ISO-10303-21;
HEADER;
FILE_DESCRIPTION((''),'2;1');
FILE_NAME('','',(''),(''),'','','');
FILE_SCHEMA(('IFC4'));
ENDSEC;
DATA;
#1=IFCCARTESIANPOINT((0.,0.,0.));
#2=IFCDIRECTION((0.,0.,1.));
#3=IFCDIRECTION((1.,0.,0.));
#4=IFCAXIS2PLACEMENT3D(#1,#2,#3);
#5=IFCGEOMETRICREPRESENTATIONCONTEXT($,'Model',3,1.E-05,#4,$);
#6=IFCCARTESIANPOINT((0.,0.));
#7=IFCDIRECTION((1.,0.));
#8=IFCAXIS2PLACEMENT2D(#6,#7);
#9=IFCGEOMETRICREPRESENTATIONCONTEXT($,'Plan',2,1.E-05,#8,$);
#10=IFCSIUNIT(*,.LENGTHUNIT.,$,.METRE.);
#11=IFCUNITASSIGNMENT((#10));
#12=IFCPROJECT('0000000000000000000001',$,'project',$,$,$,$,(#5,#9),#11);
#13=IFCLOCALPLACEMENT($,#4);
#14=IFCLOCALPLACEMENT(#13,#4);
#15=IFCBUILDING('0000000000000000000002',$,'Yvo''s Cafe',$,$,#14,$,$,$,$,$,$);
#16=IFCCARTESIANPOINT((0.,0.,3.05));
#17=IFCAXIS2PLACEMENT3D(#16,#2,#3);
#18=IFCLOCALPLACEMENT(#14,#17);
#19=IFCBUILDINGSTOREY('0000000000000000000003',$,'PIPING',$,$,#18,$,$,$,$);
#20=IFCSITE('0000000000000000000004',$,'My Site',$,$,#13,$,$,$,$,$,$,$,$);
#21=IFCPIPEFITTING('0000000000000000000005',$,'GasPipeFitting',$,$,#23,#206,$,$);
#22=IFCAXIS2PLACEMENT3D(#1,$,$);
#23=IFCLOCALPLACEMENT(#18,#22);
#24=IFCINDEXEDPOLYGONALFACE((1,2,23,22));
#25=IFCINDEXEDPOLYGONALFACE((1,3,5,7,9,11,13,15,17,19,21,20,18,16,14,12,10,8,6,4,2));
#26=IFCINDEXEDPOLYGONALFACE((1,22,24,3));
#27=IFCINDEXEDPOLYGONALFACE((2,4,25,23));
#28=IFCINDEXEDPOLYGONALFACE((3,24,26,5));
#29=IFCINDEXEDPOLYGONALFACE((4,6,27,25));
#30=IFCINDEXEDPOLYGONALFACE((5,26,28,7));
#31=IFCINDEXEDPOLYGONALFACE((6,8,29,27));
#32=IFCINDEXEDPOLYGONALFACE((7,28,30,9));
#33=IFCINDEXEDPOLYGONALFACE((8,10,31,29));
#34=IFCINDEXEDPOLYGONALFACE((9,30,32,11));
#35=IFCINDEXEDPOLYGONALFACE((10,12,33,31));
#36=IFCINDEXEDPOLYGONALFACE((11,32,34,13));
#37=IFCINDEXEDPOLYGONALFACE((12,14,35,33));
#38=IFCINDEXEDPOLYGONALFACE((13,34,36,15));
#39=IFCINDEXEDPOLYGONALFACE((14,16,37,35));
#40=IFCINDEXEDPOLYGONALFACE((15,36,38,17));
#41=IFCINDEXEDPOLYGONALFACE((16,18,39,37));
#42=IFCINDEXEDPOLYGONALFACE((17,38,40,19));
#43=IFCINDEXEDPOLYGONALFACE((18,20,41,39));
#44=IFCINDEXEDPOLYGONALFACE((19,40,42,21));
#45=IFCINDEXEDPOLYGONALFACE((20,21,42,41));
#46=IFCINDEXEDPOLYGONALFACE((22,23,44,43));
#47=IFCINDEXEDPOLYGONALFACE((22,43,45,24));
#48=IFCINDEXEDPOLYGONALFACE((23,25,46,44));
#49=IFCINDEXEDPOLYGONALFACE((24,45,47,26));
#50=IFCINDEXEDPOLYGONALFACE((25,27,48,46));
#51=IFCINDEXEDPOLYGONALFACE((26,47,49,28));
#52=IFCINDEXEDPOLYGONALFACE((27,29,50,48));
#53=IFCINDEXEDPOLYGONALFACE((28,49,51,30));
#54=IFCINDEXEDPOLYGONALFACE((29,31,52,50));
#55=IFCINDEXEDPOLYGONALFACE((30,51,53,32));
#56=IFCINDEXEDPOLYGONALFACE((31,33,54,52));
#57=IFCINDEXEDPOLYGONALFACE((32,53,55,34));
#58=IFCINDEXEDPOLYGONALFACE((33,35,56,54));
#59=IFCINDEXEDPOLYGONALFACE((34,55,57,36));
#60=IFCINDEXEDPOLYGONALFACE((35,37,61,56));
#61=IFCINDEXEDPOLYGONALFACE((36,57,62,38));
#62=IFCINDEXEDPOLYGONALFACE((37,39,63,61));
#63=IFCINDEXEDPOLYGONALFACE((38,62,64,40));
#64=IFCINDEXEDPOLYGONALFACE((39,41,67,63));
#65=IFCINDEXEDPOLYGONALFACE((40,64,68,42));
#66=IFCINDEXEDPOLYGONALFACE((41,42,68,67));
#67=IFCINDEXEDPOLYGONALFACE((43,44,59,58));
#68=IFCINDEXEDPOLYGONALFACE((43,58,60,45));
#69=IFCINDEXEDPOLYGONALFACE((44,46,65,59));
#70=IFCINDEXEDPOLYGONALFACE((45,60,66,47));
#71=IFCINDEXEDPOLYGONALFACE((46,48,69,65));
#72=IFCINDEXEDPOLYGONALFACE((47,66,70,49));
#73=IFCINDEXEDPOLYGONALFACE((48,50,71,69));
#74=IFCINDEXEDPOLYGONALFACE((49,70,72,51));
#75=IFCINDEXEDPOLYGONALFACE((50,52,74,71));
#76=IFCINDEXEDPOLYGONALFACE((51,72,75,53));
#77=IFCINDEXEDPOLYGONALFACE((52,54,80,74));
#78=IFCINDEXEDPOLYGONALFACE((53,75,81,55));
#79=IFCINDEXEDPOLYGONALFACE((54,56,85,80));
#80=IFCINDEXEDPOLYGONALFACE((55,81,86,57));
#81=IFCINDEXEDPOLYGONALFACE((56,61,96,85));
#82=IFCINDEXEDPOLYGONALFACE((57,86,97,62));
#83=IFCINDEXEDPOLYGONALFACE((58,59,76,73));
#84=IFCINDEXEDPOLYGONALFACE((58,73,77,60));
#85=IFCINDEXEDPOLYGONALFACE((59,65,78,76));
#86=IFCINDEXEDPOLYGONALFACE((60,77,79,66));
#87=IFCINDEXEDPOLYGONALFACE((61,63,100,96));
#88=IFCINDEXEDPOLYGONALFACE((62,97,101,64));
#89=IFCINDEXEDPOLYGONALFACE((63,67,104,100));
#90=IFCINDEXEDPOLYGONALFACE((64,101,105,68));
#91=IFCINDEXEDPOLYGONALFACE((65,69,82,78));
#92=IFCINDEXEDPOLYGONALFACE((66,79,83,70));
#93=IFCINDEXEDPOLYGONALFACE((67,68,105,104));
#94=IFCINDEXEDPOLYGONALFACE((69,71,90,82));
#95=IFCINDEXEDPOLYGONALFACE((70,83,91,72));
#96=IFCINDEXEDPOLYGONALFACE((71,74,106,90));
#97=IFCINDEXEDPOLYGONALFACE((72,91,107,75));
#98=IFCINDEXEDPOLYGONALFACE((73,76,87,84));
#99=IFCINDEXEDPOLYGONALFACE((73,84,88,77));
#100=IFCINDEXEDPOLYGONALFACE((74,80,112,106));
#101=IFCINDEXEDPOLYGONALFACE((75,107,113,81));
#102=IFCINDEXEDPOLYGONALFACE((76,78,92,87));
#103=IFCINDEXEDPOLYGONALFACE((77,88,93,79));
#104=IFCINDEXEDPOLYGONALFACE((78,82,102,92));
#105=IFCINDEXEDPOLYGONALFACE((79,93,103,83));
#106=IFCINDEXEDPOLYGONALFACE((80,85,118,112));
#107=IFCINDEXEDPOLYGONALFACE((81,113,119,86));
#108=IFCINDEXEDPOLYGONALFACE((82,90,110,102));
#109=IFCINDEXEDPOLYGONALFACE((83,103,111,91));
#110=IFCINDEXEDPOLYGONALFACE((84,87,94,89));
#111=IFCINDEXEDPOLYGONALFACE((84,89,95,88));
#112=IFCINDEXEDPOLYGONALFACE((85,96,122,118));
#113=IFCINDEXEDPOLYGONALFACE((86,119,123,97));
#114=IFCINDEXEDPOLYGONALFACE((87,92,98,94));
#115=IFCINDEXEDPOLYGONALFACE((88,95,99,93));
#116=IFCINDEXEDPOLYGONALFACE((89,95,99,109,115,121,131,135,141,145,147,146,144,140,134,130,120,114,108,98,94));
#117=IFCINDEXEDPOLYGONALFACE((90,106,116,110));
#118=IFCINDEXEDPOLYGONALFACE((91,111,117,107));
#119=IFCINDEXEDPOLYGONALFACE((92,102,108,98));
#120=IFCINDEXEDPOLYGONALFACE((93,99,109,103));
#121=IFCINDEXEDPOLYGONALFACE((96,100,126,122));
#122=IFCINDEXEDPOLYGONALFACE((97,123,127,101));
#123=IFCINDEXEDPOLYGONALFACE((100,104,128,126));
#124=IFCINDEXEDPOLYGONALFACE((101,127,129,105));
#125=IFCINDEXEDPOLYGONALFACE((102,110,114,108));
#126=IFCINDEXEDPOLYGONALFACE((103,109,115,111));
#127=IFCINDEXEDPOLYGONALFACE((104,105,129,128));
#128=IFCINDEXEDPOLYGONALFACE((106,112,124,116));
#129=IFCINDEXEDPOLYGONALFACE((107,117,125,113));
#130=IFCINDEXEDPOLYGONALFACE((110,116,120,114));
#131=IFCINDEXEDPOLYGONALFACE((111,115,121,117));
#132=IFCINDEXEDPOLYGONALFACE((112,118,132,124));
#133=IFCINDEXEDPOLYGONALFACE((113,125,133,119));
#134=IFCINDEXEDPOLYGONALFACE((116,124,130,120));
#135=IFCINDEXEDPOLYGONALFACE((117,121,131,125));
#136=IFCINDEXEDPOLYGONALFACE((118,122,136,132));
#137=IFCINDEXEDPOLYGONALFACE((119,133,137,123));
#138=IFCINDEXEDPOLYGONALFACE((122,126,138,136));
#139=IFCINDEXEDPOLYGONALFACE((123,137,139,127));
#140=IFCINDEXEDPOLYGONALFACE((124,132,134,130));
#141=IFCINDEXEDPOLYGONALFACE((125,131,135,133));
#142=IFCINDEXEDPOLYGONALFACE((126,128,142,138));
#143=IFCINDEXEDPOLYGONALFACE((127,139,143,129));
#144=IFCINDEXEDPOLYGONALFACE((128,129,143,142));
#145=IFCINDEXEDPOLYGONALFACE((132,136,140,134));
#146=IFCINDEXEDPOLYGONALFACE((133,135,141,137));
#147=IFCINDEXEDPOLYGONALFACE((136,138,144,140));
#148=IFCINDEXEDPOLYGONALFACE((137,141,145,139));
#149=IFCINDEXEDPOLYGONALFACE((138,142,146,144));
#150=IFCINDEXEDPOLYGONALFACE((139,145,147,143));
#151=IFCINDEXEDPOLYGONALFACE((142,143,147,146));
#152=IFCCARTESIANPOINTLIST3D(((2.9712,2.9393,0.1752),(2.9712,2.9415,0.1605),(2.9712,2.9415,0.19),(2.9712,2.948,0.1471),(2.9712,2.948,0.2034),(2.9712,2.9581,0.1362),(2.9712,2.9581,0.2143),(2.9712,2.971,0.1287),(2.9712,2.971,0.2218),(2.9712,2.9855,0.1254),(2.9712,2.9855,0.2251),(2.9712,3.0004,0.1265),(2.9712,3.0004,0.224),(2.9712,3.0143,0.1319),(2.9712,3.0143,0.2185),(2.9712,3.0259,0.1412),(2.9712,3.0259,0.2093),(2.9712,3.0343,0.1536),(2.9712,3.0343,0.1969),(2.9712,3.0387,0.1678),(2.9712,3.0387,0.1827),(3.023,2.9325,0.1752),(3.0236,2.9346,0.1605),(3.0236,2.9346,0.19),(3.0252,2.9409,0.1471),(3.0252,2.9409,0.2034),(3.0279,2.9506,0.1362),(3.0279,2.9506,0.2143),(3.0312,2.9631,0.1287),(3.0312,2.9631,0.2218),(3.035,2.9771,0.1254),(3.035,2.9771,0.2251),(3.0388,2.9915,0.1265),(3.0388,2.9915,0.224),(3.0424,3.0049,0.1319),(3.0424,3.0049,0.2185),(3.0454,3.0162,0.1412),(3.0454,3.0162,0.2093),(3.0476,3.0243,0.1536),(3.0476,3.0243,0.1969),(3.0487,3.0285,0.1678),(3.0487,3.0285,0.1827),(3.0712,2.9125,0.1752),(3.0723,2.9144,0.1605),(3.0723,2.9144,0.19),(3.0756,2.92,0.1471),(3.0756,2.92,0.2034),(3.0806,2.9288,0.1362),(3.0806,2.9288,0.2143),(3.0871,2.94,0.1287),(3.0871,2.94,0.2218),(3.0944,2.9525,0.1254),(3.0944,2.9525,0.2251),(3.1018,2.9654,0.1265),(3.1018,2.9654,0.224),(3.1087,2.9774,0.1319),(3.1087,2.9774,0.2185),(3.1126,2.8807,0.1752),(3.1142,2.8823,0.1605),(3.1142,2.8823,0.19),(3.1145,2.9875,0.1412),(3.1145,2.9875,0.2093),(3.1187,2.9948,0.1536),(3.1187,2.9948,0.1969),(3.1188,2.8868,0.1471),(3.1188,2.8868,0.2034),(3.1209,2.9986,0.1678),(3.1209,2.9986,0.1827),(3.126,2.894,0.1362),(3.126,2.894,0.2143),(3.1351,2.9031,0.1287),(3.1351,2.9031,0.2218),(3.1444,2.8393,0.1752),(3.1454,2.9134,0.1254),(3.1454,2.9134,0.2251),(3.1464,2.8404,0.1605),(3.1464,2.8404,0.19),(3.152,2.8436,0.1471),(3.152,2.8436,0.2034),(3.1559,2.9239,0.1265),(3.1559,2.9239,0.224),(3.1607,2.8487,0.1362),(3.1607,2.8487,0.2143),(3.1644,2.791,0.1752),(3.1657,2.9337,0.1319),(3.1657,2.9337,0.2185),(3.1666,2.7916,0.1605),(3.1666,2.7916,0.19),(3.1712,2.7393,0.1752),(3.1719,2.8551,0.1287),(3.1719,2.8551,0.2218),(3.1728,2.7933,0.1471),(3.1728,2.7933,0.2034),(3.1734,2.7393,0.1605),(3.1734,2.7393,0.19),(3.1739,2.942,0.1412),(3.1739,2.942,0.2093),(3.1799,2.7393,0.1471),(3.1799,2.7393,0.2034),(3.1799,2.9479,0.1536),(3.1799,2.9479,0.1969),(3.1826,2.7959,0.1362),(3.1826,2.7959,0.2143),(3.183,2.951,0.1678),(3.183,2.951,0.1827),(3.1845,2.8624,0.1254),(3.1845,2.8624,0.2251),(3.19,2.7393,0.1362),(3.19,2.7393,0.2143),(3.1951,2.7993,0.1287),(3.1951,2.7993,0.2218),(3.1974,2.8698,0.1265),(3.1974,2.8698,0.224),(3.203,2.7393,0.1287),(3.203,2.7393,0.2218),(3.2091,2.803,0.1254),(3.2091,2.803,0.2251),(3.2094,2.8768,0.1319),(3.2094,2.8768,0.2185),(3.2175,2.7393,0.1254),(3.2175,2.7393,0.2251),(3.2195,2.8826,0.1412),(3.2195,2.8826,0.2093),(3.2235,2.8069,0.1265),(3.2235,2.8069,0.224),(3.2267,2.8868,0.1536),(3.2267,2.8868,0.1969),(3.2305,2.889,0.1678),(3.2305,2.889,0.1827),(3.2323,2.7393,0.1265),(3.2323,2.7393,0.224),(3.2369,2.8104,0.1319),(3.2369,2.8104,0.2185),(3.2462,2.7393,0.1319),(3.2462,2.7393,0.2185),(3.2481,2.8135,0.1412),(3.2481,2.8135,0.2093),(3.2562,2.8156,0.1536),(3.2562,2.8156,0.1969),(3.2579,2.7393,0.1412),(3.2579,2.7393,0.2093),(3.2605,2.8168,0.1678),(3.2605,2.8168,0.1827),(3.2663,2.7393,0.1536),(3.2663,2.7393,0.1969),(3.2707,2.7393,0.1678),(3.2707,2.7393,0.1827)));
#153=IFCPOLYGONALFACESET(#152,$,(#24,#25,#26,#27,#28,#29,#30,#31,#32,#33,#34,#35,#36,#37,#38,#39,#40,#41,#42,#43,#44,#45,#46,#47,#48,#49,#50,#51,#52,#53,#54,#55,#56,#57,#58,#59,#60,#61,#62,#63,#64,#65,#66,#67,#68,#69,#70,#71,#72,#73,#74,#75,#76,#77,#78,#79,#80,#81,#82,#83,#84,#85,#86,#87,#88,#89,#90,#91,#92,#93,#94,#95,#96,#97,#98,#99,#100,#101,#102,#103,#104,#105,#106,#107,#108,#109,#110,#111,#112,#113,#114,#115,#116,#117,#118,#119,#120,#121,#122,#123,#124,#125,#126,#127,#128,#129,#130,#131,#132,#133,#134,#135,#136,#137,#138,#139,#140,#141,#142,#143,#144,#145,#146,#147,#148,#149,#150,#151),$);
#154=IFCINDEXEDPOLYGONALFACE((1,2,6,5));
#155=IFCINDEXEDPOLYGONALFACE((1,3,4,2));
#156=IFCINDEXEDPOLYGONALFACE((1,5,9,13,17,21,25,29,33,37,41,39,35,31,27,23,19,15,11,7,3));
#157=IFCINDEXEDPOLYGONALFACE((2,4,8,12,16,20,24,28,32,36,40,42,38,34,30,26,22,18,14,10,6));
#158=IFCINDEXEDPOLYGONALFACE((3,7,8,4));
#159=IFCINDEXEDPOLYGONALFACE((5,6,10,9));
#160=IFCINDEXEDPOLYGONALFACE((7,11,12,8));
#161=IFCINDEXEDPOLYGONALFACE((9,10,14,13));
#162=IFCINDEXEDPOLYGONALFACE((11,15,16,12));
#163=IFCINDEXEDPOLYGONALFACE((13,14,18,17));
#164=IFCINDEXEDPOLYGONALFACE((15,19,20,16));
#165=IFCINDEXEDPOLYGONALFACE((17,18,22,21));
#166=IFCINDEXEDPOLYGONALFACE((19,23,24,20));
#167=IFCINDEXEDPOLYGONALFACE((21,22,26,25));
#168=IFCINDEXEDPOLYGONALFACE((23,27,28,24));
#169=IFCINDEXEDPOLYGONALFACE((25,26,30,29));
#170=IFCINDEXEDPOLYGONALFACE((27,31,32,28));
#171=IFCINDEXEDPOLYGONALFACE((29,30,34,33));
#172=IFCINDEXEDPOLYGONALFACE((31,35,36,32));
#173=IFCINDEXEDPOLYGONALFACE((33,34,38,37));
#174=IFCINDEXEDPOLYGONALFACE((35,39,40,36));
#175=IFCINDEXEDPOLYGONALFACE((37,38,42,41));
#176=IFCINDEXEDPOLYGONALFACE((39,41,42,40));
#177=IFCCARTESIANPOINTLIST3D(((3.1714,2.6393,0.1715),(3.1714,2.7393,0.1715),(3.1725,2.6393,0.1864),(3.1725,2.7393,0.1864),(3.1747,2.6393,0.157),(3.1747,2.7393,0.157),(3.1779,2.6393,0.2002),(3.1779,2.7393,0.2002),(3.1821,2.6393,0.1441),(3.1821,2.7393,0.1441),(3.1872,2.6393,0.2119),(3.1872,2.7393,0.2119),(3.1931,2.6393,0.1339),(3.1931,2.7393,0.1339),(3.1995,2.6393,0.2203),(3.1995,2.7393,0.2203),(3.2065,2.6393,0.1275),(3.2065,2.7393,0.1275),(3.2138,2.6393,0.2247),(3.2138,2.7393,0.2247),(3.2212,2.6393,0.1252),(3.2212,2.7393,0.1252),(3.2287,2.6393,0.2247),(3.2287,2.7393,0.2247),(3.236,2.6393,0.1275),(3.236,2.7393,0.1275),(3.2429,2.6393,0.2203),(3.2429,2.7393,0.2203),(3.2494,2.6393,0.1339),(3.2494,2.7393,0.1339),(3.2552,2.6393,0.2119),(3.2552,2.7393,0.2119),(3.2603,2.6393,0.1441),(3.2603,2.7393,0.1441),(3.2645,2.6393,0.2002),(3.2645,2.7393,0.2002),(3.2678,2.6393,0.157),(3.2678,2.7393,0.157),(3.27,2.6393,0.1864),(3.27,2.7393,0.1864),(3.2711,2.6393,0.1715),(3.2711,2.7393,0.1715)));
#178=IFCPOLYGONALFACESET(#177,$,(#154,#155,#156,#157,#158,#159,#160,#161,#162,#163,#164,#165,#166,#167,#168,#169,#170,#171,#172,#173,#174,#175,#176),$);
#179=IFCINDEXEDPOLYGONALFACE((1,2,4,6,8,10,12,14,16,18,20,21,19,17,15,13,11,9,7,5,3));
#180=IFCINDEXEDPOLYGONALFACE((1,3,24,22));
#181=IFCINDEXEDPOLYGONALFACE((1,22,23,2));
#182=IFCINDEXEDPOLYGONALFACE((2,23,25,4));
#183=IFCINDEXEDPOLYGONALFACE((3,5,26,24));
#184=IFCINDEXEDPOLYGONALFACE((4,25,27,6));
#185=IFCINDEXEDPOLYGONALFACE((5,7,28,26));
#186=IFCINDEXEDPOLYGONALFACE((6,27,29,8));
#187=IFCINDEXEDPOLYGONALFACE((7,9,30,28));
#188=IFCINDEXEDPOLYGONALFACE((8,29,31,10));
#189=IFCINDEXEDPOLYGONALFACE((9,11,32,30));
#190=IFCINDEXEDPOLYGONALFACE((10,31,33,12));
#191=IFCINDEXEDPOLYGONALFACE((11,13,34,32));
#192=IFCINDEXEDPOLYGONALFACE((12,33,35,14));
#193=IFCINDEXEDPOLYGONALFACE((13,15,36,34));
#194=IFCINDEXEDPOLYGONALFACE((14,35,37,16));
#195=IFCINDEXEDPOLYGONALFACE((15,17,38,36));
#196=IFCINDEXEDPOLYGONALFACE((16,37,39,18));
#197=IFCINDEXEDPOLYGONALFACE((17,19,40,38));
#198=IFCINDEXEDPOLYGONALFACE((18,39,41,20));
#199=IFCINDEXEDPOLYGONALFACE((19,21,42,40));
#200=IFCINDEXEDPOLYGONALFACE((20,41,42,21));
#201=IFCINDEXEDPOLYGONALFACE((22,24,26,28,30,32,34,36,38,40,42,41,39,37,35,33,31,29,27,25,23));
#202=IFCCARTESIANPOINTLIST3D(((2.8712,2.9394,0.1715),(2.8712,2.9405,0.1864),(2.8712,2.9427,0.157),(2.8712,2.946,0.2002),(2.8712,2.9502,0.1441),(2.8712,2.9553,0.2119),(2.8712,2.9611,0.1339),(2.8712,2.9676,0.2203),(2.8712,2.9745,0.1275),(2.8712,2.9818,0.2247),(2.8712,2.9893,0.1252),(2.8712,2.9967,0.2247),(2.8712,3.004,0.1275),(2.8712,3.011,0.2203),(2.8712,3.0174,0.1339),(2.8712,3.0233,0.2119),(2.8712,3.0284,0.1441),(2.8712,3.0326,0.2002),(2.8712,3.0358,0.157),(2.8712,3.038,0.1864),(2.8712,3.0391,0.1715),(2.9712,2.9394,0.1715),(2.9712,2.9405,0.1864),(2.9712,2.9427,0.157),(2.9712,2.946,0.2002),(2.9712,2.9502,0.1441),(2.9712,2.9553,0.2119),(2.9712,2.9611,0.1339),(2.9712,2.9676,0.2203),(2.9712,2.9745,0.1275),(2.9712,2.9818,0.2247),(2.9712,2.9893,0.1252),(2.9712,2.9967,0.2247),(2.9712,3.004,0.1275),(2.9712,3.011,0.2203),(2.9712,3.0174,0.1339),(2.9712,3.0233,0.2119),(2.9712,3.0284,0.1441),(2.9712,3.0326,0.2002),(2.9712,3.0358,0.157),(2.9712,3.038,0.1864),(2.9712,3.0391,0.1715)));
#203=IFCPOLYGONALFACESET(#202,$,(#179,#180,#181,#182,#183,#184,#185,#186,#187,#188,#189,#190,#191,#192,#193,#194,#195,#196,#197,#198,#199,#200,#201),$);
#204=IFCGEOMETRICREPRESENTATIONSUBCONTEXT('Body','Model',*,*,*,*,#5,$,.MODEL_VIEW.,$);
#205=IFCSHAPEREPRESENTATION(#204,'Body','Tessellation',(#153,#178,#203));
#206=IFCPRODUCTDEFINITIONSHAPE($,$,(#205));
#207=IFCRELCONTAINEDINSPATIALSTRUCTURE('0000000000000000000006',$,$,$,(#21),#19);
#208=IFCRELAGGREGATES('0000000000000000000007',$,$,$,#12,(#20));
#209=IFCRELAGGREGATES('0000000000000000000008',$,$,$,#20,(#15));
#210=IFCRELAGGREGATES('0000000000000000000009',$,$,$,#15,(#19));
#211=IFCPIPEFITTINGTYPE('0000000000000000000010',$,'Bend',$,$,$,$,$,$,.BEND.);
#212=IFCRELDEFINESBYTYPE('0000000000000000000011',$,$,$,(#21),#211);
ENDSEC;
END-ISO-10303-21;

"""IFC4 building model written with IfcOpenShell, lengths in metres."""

from ifc_helpers import new_model, entity, si_unit, frame, origin_with_axes, origin_2d_with_axis, place, context, subcontext, project, spatial, circle, extrude, source, transform, mapped, type_object, type_shapes, element, save


model = new_model("IFC4")

# Units and contexts
model_context = context("Model", 3, precision=1e-05, world=origin_with_axes())
plan_context = context("Plan", 2, precision=1e-05, world=origin_2d_with_axis())
body_context = subcontext(model_context, "Body", "Model", "MODEL_VIEW")
ifc_project = project(units=[si_unit("LENGTHUNIT", "METRE")], contexts=[model_context, plan_context])

# Site, building, storey
site_placement = place(None, origin_with_axes())
site = spatial("IfcSite", under=ifc_project, at=site_placement, Name="My Site")
building_placement = place(site_placement, origin_with_axes())
building = spatial("IfcBuilding", under=site, at=building_placement, Name="Yvo's Cafe")
storey_placement = place(building_placement, frame((0.0, 0.0, 3.05), z_axis=(0.0, 0.0, 1.0), x_axis=(1.0, 0.0, 0.0)))
storey = spatial("IfcBuildingStorey", under=building, at=storey_placement, Name="PIPING")

# Shared definitions
pipe_fitting_type_1 = type_object("IfcPipeFittingType", Name="Bend", PredefinedType="BEND")
shared_shape_1 = source(origin_with_axes(), body_context, "Body", "SolidModel", [
    entity("IfcSweptDiskSolid", entity("IfcIndexedPolyCurve", entity("IfcCartesianPointList3D", [[0.0, 0.0, -0.1], [0.0, -0.0732, -0.2768], [0.0, -0.25, -0.35]]), [entity("IfcArcIndex", [1, 2, 3])]), 0.05),
    extrude(circle(Radius=0.05), origin_with_axes(), (0.0, 0.0, -1.0), 0.1),
    extrude(circle(Radius=0.05), frame((0.0, -0.25, -0.35), z_axis=(0.0, -1.0, 0.0), x_axis=(1.0, 0.0, 0.0)), (0.0, 0.0, 1.0), 0.1),
])
type_shapes(pipe_fitting_type_1, [shared_shape_1])

# Pipe fitting
for number, where, z_axis, x_axis, name in (
    (1, (3.2212, 2.6393, 0.1752), (0.0, -1.0, 0.0), (0.0, 0.0, -1.0), "GasPipeFitting"),
):
    element("IfcPipeFitting", number, at=place(storey_placement, frame(where, z_axis=z_axis, x_axis=x_axis)), inside=storey, type_object=pipe_fitting_type_1, Name=name, context=body_context, shape_type="MappedRepresentation", body=[
        mapped(shared_shape_1, transform((0.0, 0.0, 0.0), x_axis=(1.0, 0.0, 0.0), y_axis=(0.0, 1.0, 0.0), z_axis=(0.0, 0.0, 1.0), scale=1.0)),
    ])

save(model, "model.ifc")
